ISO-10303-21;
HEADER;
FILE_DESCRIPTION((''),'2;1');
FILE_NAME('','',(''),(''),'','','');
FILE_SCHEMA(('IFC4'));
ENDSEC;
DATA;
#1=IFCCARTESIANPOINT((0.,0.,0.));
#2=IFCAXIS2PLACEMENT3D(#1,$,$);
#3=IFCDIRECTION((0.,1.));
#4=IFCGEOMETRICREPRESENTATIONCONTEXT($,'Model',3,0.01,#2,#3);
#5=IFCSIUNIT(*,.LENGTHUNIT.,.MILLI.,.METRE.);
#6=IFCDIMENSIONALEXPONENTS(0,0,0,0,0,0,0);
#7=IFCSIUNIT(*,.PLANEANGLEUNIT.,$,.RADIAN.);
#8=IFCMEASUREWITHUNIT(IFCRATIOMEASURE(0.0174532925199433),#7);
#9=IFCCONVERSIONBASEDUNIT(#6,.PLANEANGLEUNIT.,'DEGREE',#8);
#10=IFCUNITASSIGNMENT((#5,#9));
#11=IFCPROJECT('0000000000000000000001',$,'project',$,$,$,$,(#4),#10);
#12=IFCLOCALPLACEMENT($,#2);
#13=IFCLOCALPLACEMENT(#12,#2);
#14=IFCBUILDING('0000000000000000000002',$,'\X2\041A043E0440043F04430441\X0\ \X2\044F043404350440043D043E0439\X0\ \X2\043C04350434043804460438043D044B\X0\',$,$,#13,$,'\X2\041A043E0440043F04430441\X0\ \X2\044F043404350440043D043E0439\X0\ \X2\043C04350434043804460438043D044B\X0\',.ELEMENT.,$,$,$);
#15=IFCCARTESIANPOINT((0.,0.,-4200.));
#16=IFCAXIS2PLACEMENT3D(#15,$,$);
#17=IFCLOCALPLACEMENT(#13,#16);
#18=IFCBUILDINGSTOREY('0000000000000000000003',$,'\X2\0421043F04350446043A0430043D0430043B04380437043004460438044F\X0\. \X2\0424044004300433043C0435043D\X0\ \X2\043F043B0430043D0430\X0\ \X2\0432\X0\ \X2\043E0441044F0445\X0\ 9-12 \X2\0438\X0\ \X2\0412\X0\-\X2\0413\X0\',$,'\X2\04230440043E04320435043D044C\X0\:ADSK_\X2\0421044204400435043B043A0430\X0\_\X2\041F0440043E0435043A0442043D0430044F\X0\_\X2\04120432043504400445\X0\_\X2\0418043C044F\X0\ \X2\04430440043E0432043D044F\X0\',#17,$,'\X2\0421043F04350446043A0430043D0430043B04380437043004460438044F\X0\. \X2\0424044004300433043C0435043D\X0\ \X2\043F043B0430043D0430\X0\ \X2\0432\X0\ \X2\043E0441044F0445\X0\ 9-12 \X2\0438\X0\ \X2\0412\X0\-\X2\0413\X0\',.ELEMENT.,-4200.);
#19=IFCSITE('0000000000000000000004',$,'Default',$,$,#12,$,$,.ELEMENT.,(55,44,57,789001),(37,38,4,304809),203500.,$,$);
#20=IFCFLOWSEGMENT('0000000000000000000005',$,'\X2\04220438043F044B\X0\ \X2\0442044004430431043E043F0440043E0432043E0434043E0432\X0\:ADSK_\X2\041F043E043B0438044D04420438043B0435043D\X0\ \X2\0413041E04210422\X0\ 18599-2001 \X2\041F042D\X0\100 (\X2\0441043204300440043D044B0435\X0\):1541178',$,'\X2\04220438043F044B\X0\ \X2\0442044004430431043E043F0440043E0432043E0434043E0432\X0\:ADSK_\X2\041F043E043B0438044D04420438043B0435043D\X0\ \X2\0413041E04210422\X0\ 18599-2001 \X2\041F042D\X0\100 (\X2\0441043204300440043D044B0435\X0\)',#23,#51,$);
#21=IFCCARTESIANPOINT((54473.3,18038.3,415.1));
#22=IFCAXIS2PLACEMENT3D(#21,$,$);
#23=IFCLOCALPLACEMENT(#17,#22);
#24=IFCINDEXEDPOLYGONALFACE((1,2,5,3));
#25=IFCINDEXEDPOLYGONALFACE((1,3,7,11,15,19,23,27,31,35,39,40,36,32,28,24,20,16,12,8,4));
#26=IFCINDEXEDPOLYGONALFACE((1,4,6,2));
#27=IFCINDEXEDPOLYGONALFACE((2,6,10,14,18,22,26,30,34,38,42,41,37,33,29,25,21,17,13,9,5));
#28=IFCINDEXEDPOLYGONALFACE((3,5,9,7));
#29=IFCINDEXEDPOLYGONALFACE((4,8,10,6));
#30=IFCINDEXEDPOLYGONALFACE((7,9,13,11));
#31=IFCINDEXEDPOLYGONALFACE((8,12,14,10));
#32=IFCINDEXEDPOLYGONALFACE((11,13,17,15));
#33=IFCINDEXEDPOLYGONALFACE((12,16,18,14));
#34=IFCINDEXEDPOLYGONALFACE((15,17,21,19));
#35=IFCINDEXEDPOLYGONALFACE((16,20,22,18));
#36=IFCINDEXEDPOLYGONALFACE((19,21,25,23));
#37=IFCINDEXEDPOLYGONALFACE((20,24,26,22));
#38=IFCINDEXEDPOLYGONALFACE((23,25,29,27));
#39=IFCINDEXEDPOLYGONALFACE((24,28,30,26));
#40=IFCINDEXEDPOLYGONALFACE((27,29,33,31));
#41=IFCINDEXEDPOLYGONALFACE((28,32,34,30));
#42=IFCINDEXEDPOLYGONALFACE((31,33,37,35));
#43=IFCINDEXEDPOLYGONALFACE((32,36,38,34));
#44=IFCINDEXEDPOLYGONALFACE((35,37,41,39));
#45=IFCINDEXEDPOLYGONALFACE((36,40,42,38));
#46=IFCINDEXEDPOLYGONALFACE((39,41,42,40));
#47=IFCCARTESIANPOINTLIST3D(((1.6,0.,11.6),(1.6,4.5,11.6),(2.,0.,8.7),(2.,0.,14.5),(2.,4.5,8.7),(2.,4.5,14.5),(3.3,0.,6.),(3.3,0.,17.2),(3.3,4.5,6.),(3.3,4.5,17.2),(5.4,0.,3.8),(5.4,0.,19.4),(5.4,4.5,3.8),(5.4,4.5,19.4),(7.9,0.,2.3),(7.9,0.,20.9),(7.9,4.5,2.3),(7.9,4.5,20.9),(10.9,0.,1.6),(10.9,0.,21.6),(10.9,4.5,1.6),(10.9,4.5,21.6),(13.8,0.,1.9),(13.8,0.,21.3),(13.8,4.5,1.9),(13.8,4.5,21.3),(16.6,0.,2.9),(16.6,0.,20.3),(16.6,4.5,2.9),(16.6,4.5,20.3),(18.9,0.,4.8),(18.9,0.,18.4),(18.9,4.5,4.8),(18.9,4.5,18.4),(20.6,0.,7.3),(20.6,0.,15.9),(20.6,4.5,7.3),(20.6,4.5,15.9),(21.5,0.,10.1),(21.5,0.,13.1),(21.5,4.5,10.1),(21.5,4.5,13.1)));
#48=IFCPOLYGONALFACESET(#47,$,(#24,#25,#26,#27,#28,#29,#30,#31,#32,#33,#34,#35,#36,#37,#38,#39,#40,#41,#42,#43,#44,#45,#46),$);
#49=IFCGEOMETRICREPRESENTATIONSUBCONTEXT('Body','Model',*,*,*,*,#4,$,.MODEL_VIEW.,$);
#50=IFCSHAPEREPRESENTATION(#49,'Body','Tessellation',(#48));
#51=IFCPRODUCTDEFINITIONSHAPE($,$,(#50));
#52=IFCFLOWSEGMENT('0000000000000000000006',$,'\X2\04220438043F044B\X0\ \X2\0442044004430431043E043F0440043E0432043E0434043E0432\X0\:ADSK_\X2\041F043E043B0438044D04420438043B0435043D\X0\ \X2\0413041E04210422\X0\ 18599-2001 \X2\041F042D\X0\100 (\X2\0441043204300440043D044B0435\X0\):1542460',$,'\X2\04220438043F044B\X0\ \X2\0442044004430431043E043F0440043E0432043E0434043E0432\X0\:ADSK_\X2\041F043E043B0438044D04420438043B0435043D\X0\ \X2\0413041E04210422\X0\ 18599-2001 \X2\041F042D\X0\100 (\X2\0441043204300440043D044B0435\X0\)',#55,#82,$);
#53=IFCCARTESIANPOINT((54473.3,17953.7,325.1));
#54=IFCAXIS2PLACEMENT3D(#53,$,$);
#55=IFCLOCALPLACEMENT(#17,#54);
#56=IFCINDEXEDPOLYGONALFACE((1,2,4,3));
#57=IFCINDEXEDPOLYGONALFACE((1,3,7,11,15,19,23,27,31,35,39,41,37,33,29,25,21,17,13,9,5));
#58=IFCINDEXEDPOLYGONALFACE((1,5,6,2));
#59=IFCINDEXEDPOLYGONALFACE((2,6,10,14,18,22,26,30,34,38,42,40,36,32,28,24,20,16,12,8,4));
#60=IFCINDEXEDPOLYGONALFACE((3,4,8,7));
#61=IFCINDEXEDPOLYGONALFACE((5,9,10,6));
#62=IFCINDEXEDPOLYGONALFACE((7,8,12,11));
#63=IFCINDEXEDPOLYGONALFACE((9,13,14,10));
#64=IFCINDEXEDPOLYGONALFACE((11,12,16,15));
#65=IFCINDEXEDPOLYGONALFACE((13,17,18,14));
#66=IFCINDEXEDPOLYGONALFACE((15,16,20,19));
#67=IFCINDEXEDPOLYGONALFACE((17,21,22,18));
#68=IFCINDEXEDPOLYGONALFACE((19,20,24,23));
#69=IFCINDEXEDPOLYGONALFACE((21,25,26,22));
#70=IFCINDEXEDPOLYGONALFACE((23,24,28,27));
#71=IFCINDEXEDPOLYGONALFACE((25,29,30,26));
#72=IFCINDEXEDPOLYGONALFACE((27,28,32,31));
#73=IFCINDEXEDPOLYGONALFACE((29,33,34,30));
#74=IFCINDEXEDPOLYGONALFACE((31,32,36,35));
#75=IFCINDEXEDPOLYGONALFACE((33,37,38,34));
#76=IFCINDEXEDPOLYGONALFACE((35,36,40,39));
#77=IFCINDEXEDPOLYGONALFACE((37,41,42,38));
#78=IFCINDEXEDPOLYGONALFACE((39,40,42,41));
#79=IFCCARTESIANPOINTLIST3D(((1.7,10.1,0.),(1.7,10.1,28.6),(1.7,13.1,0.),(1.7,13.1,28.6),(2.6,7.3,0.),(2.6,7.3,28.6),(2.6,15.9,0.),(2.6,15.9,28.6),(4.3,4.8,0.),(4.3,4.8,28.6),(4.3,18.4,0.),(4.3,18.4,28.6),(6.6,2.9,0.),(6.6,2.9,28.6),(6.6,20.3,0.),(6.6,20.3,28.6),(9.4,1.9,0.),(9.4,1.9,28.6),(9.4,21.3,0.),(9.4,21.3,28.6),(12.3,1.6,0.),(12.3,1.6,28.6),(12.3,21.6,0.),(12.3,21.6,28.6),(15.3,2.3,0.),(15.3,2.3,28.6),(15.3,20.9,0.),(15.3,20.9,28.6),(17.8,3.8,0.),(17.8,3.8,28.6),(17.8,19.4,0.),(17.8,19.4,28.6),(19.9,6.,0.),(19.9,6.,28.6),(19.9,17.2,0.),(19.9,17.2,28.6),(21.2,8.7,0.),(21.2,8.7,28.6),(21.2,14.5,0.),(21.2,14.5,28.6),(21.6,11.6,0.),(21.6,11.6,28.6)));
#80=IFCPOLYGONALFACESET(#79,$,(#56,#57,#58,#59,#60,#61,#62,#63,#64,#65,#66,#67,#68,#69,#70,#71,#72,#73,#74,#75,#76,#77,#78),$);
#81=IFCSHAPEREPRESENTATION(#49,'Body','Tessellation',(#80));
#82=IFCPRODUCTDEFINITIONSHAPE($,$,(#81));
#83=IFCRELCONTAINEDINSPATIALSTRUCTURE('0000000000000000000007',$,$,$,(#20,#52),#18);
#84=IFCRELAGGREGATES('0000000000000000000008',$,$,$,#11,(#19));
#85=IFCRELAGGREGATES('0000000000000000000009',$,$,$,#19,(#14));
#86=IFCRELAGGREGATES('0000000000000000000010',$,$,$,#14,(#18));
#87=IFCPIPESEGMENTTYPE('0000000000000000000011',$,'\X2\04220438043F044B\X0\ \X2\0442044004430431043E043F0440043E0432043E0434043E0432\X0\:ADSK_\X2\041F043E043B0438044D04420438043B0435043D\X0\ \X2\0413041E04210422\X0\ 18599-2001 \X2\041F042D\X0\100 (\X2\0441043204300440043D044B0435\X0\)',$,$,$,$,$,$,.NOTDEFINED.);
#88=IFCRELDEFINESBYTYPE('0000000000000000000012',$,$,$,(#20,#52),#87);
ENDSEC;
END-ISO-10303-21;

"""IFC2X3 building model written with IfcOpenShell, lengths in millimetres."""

from ifc_helpers import new_model, entity, si_unit, converted_unit, direction, frame, origin, origin_2d_with_axis, place, context, subcontext, project, spatial, circle, extrude, type_object, element, save


model = new_model("IFC2X3")

# Units and contexts
model_context = context("Model", 3, precision=0.01, world=origin(), true_north=direction((0.0, 1.0)))
body_context = subcontext(model_context, "Body", "Model", "MODEL_VIEW")
ifc_project = project(units=[si_unit("LENGTHUNIT", "METRE", prefix="MILLI"), converted_unit("PLANEANGLEUNIT", "DEGREE", entity("IfcRatioMeasure", 0.0174532925199433), si_unit("PLANEANGLEUNIT", "RADIAN"), dimensions=[0, 0, 0, 0, 0, 0, 0])], contexts=[model_context])

# Site, building, storey
site_placement = place(None, origin())
site = spatial("IfcSite", under=ifc_project, at=site_placement, Name="Default", CompositionType="ELEMENT", RefLatitude=(55, 44, 57, 789001), RefLongitude=(37, 38, 4, 304809), RefElevation=203500.0)
building_placement = place(site_placement, origin())
building = spatial("IfcBuilding", under=site, at=building_placement, Name="Корпус ядерной медицины", LongName="Корпус ядерной медицины", CompositionType="ELEMENT")
storey_placement = place(building_placement, frame((0.0, 0.0, -4200.0)))
storey = spatial("IfcBuildingStorey", under=building, at=storey_placement, Name="Спецканализация. Фрагмен плана в осях 9-12 и В-Г", ObjectType="Уровень:ADSK_Стрелка_Проектная_Вверх_Имя уровня", LongName="Спецканализация. Фрагмен плана в осях 9-12 и В-Г", CompositionType="ELEMENT", Elevation=-4200.0)

# Flow segments
pipe_segment_type = type_object("IfcPipeSegmentType", Name="Типы трубопроводов:ADSK_Полиэтилен ГОСТ 18599-2001 ПЭ100 (сварные)", PredefinedType="NOTDEFINED")
flow_segment_1_placement = place(storey_placement, frame((54473.3, 18038.3, 415.1)))
element("IfcFlowSegment", 1, at=flow_segment_1_placement, inside=storey, type_object=pipe_segment_type, Name="Типы трубопроводов:ADSK_Полиэтилен ГОСТ 18599-2001 ПЭ100 (сварные):1541178", ObjectType="Типы трубопроводов:ADSK_Полиэтилен ГОСТ 18599-2001 ПЭ100 (сварные)", context=body_context, shape_type="SweptSolid", body=[
    extrude(circle(Radius=10.0, at=origin_2d_with_axis()), frame((11.6, 0.0, 11.6), z_axis=(0.0, 1.0, 0.0), x_axis=(-1.0, 0.0, 0.0)), (0.0, 0.0, 1.0), 4.5),
])
flow_segment_2_placement = place(storey_placement, frame((54473.3, 17953.7, 325.1)))
element("IfcFlowSegment", 2, at=flow_segment_2_placement, inside=storey, type_object=pipe_segment_type, Name="Типы трубопроводов:ADSK_Полиэтилен ГОСТ 18599-2001 ПЭ100 (сварные):1542460", ObjectType="Типы трубопроводов:ADSK_Полиэтилен ГОСТ 18599-2001 ПЭ100 (сварные)", context=body_context, shape_type="SweptSolid", body=[
    extrude(circle(Radius=10.0, at=origin_2d_with_axis()), frame((11.6, 11.6, 0.0)), (0.0, 0.0, 1.0), 28.6),
])

save(model, "model.ifc")
